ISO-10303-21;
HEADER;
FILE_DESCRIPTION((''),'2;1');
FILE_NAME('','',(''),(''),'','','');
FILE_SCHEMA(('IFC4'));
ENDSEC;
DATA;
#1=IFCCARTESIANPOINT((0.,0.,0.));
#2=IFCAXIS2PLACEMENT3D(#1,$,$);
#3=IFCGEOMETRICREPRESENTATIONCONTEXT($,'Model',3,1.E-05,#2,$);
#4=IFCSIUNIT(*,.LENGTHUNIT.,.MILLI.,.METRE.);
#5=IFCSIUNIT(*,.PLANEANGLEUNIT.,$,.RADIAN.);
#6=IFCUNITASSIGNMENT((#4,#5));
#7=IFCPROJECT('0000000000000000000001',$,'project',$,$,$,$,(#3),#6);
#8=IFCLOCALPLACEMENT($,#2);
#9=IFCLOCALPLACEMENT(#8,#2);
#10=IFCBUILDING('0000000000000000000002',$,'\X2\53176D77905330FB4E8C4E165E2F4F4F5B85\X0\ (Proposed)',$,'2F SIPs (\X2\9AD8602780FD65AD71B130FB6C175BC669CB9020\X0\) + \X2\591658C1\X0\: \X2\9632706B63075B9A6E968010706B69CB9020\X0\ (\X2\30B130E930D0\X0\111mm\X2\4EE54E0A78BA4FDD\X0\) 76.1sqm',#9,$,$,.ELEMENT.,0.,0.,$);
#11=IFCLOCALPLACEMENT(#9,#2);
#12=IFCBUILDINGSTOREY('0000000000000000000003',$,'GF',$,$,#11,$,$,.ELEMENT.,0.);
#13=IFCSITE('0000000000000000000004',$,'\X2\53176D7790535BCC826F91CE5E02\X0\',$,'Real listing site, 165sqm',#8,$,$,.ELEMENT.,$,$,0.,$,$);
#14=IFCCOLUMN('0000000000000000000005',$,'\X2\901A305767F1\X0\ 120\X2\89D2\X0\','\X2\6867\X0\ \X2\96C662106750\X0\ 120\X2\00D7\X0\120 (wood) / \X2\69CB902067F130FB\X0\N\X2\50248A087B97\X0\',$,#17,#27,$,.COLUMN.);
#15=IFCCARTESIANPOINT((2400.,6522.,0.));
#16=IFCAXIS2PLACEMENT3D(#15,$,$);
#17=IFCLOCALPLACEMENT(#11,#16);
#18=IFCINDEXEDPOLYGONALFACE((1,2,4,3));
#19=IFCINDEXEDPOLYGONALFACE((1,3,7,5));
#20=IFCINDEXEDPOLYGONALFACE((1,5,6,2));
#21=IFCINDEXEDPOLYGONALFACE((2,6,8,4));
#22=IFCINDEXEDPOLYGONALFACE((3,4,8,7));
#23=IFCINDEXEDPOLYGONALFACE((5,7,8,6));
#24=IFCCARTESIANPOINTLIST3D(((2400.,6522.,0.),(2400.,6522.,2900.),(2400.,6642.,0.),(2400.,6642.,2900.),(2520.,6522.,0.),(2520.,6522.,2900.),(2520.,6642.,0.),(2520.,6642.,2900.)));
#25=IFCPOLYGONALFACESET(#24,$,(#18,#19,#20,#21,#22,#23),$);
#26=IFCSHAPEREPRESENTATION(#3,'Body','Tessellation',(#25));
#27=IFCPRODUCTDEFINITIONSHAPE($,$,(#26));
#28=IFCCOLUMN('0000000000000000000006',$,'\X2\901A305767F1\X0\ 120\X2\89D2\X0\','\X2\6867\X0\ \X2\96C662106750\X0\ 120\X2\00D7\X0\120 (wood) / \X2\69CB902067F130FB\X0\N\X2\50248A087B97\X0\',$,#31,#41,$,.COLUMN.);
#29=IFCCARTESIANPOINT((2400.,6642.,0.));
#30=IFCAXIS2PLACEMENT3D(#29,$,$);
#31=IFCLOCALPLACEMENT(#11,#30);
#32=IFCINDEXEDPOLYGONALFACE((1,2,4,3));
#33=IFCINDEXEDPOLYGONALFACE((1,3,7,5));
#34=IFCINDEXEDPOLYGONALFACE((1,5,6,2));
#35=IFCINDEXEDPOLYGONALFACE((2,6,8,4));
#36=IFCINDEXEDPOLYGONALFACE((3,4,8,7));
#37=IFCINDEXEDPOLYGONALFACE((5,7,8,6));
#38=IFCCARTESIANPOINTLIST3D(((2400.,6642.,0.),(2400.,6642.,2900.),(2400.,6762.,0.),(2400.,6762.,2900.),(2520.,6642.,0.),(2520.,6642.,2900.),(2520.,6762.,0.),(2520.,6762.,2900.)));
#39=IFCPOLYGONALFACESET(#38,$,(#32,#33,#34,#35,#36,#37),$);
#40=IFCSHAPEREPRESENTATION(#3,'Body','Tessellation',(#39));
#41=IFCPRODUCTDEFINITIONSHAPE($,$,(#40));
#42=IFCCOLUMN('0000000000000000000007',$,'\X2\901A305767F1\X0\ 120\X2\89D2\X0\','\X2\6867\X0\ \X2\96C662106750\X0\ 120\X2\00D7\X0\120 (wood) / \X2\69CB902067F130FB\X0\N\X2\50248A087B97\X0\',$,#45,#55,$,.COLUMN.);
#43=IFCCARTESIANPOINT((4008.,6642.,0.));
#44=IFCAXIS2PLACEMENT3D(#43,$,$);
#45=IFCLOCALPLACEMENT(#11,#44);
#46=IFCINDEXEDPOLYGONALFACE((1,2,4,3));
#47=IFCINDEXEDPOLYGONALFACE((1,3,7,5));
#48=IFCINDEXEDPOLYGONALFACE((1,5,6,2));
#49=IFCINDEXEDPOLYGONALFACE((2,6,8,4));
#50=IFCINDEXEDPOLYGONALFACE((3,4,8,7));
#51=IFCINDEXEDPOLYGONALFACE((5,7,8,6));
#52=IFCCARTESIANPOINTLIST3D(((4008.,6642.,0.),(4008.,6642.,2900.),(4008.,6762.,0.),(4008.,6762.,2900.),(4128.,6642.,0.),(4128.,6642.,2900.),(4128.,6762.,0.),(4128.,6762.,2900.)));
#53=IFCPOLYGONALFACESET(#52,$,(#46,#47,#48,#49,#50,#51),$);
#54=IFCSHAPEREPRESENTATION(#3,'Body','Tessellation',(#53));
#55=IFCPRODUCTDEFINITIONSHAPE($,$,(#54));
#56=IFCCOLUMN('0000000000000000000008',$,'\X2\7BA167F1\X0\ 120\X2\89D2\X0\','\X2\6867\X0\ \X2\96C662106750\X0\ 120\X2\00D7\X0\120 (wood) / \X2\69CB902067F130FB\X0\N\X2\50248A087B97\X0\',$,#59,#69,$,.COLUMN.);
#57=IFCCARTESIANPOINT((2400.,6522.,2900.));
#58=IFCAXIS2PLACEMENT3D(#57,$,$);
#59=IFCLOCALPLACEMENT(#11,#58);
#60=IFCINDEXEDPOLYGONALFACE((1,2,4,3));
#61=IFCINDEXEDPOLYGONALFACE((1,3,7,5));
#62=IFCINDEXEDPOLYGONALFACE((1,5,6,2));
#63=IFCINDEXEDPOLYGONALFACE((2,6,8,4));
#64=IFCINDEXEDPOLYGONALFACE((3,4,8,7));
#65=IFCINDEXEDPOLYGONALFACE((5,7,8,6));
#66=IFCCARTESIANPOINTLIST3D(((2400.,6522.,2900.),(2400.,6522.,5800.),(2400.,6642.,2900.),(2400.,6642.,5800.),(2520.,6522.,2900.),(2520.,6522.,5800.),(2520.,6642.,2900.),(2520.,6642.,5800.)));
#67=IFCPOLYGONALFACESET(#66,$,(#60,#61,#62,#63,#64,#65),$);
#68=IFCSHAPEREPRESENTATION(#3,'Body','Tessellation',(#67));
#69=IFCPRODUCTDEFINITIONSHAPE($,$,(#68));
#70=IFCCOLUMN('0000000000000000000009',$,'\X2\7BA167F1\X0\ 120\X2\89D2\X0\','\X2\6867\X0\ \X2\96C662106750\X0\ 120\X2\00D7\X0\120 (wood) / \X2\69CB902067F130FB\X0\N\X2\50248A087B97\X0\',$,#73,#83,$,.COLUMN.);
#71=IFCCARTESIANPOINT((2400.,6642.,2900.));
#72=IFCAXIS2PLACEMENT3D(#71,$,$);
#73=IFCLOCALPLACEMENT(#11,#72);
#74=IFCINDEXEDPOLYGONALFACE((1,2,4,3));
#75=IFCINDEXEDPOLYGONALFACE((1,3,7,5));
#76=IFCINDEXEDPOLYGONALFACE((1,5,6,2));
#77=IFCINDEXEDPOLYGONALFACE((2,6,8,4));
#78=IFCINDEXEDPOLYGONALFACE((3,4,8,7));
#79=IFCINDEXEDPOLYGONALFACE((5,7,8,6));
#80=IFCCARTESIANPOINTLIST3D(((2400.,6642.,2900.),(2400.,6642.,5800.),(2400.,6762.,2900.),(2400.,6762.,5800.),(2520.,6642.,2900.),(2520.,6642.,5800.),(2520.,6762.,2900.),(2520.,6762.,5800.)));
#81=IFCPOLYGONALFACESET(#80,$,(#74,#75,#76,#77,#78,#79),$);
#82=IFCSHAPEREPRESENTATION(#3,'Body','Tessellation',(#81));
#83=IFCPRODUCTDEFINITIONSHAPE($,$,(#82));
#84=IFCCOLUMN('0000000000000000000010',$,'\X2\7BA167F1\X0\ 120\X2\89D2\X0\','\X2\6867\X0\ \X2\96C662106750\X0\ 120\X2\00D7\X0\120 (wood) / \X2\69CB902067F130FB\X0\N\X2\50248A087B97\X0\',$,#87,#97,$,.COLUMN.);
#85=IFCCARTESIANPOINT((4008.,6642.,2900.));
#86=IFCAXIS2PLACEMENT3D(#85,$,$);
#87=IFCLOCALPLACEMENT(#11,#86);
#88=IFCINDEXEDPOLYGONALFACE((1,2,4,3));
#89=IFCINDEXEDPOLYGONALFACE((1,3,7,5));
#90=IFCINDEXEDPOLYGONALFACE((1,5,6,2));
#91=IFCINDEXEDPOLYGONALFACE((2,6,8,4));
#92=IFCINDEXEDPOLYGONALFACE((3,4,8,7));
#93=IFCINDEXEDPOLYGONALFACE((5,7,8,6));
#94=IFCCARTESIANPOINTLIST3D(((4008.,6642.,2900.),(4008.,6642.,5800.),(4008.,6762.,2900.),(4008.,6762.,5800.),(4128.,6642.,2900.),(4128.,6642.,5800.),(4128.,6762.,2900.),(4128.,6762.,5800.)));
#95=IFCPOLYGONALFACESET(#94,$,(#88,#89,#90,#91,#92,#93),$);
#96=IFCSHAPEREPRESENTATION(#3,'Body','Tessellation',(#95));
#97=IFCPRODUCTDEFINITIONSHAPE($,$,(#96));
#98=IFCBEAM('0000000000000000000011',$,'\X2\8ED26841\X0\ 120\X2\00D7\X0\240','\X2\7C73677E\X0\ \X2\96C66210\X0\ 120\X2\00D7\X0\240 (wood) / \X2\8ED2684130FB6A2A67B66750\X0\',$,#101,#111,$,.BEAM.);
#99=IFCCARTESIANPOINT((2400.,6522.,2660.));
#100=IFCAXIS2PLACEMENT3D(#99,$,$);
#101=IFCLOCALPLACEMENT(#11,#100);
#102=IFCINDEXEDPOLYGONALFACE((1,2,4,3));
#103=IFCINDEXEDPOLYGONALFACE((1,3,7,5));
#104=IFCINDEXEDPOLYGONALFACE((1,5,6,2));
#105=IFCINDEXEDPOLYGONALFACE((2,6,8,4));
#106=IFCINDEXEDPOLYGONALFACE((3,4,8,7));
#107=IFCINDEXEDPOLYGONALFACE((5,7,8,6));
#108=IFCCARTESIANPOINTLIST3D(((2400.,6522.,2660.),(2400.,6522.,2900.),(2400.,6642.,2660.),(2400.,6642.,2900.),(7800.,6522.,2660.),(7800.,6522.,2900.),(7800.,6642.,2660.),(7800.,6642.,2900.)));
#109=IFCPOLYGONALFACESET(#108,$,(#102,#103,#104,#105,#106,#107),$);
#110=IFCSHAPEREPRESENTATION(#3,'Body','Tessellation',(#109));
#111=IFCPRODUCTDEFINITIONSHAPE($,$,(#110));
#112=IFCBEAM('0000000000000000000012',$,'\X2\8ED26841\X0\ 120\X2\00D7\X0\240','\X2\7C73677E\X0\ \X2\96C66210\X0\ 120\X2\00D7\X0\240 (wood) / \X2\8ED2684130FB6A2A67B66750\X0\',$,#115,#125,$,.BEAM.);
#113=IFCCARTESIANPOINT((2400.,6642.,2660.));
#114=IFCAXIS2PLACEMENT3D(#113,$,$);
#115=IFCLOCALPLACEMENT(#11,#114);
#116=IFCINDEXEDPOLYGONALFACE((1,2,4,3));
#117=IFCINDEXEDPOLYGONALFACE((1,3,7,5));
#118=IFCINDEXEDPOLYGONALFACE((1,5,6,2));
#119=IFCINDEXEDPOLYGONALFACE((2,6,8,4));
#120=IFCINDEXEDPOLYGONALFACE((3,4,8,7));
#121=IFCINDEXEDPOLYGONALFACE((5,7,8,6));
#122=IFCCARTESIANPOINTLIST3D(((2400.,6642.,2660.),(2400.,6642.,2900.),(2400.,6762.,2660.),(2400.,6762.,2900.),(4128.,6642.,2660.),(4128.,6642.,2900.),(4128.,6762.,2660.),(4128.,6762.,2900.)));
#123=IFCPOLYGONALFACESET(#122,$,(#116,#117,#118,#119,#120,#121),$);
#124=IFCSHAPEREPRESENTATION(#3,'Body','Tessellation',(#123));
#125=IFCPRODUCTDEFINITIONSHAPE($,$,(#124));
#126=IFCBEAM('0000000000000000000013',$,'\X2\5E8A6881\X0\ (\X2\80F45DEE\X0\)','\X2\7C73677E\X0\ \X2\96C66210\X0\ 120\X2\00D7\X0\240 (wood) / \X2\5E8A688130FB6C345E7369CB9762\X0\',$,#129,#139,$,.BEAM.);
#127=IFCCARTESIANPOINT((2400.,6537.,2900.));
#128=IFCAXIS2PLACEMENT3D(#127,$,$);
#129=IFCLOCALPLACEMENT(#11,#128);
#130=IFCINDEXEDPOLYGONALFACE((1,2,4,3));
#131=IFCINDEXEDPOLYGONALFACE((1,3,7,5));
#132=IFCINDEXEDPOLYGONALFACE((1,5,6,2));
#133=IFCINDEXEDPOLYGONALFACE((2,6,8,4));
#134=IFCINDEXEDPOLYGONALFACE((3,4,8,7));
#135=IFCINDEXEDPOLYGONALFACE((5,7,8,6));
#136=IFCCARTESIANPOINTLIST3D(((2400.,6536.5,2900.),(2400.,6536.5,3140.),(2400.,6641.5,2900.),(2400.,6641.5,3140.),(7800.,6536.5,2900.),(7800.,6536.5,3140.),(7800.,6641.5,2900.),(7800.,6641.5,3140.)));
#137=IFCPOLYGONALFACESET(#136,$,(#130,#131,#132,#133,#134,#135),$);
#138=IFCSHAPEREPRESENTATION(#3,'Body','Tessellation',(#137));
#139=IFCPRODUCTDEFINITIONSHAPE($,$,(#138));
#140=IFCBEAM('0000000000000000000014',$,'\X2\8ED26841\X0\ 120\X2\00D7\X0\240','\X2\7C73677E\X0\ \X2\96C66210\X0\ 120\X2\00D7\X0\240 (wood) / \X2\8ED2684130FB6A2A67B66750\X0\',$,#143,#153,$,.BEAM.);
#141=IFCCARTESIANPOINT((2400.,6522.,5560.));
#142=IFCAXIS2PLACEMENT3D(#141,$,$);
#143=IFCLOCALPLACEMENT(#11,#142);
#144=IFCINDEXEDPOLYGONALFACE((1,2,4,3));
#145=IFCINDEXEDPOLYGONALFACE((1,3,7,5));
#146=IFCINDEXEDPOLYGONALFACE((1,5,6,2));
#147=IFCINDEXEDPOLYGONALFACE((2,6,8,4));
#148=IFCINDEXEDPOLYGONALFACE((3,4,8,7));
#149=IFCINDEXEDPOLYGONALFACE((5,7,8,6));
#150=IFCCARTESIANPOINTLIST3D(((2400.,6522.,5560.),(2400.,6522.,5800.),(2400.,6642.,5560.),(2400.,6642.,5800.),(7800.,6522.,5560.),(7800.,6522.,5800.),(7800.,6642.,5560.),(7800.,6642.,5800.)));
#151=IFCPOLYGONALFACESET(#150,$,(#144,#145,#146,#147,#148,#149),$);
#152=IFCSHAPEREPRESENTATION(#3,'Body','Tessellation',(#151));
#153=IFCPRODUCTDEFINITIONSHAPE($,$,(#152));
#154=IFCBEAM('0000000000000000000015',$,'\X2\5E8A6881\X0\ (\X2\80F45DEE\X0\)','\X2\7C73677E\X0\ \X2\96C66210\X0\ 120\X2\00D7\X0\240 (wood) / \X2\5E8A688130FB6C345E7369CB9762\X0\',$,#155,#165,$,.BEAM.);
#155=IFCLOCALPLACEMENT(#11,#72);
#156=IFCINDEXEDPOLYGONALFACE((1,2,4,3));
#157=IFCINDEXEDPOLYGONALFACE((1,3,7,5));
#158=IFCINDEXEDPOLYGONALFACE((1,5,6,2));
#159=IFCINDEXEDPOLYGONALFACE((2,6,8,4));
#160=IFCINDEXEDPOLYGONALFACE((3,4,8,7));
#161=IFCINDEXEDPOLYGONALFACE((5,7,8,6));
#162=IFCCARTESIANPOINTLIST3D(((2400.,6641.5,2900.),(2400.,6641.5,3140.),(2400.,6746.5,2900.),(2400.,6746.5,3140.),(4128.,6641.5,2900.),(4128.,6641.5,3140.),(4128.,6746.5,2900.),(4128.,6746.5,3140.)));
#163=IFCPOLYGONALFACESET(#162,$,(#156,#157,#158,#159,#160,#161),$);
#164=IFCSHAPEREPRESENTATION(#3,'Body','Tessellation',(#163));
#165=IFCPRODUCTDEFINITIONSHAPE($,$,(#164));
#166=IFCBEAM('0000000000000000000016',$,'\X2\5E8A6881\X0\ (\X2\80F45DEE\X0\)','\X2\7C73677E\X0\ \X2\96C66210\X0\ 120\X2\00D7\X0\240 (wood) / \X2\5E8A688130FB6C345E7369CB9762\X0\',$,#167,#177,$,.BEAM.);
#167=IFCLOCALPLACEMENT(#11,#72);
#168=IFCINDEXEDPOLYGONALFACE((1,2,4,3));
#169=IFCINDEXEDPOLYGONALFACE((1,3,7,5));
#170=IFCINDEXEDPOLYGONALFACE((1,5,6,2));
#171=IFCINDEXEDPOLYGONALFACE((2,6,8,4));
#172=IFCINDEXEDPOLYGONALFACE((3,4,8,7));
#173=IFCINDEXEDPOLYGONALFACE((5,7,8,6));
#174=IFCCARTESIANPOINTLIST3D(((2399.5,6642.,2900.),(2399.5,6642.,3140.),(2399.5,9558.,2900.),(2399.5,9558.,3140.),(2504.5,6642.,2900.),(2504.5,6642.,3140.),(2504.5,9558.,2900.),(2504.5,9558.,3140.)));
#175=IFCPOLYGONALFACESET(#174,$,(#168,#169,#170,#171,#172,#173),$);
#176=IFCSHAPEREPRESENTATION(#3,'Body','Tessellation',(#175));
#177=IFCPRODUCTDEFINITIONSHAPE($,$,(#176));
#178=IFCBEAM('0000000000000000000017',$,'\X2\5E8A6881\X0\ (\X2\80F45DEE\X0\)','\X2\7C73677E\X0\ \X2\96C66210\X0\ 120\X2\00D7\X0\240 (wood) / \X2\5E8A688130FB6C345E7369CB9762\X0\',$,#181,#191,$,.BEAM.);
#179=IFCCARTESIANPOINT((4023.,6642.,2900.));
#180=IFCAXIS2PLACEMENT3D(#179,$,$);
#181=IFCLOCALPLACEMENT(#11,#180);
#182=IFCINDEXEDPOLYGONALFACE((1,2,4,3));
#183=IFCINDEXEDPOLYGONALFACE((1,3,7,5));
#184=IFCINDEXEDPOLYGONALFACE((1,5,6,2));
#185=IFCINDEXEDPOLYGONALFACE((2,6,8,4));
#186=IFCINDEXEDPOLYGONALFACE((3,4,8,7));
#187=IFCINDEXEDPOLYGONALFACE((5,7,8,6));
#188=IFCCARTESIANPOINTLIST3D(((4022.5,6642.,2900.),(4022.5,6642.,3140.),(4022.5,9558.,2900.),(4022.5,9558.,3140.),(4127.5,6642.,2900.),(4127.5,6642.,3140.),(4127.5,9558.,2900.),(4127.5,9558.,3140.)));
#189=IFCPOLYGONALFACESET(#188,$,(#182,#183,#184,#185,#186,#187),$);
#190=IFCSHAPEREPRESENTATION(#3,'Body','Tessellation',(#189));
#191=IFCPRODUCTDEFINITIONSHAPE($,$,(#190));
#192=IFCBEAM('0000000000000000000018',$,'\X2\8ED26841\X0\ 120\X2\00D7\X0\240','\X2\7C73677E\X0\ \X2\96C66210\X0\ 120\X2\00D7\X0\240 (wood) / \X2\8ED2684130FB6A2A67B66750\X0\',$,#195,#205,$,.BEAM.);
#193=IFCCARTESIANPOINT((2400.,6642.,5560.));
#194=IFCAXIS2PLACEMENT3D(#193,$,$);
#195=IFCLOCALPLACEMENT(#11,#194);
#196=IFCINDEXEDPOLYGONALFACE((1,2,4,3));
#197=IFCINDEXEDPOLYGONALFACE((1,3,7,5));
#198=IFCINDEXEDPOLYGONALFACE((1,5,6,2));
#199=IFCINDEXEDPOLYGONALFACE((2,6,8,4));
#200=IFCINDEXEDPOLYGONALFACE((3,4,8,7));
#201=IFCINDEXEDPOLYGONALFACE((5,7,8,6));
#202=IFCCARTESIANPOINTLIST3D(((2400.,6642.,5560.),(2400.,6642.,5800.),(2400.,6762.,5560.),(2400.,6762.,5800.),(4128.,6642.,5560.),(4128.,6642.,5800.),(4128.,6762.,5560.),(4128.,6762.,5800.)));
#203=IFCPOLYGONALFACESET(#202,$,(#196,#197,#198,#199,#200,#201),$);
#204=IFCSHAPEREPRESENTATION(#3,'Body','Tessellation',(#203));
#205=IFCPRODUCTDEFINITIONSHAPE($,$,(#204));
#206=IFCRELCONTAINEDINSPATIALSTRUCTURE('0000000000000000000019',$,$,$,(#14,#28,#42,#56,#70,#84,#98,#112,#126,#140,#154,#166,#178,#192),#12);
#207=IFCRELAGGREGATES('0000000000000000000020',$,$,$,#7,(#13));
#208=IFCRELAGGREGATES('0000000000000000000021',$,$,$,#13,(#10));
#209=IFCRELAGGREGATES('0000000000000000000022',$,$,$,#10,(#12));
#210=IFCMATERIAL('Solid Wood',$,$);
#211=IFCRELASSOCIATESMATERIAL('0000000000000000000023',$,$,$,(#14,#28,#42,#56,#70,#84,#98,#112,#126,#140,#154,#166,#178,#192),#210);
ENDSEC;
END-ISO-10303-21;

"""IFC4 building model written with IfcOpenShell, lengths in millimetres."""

from ifc_helpers import new_model, si_unit, frame, frame_2d, origin, place, context, project, spatial, rectangle, extrude, material, element, save


model = new_model("IFC4")

# Units and contexts
model_context = context("Model", 3, precision=1e-05, world=origin())
ifc_project = project(units=[si_unit("LENGTHUNIT", "METRE", prefix="MILLI"), si_unit("PLANEANGLEUNIT", "RADIAN")], contexts=[model_context])

# Site, building, storey
site_placement = place(None, origin())
site = spatial("IfcSite", under=ifc_project, at=site_placement, Name="北海道富良野市", ObjectType="Real listing site, 165sqm", CompositionType="ELEMENT", RefElevation=0.0)
building_placement = place(site_placement, origin())
building = spatial("IfcBuilding", under=site, at=building_placement, Name="北海道・二世帯住宅 (Proposed)", ObjectType="2F SIPs (高性能断熱・気密構造) + 外壁: 防火指定準耐火構造 (ケラバ111mm以上確保) 76.1sqm", CompositionType="ELEMENT", ElevationOfRefHeight=0.0, ElevationOfTerrain=0.0)
storey_placement = place(building_placement, origin())
storey = spatial("IfcBuildingStorey", under=building, at=storey_placement, Name="GF", CompositionType="ELEMENT", Elevation=0.0)

# Columns
ifc_material_1 = material(Name="Solid Wood")
column_1_placement = place(storey_placement, frame((2400.0, 6522.0, 0.0)))
element("IfcColumn", 1, at=column_1_placement, inside=storey, material=ifc_material_1, Name="通し柱 120角", Description="桧 集成材 120×120 (wood) / 構造柱・N値計算", PredefinedType="COLUMN", context=model_context, shape_type="SweptSolid", body=[
    extrude(rectangle(XDim=120.0, YDim=120.0, at=frame_2d((60.0, 60.0))), frame((2400.0, 6522.0, 0.0)), (0.0, 0.0, 1.0), 2900.0),
])
column_2_placement = place(storey_placement, frame((2400.0, 6642.0, 0.0)))
element("IfcColumn", 2, at=column_2_placement, inside=storey, material=ifc_material_1, Name="通し柱 120角", Description="桧 集成材 120×120 (wood) / 構造柱・N値計算", PredefinedType="COLUMN", context=model_context, shape_type="SweptSolid", body=[
    extrude(rectangle(XDim=120.0, YDim=120.0, at=frame_2d((60.0, 60.0))), frame((2400.0, 6642.0, 0.0)), (0.0, 0.0, 1.0), 2900.0),
])
column_3_placement = place(storey_placement, frame((4008.0, 6642.0, 0.0)))
element("IfcColumn", 3, at=column_3_placement, inside=storey, material=ifc_material_1, Name="通し柱 120角", Description="桧 集成材 120×120 (wood) / 構造柱・N値計算", PredefinedType="COLUMN", context=model_context, shape_type="SweptSolid", body=[
    extrude(rectangle(XDim=120.0, YDim=120.0, at=frame_2d((60.0, 60.0))), frame((4008.0, 6642.0, 0.0)), (0.0, 0.0, 1.0), 2900.0),
])
column_4_placement = place(storey_placement, frame((2400.0, 6522.0, 2900.0)))
element("IfcColumn", 4, at=column_4_placement, inside=storey, material=ifc_material_1, Name="管柱 120角", Description="桧 集成材 120×120 (wood) / 構造柱・N値計算", PredefinedType="COLUMN", context=model_context, shape_type="SweptSolid", body=[
    extrude(rectangle(XDim=120.0, YDim=120.0, at=frame_2d((60.0, 60.0))), frame((2400.0, 6522.0, 2900.0)), (0.0, 0.0, 1.0), 2900.0),
])
column_5_placement = place(storey_placement, frame((2400.0, 6642.0, 2900.0)))
element("IfcColumn", 5, at=column_5_placement, inside=storey, material=ifc_material_1, Name="管柱 120角", Description="桧 集成材 120×120 (wood) / 構造柱・N値計算", PredefinedType="COLUMN", context=model_context, shape_type="SweptSolid", body=[
    extrude(rectangle(XDim=120.0, YDim=120.0, at=frame_2d((60.0, 60.0))), frame((2400.0, 6642.0, 2900.0)), (0.0, 0.0, 1.0), 2900.0),
])
column_6_placement = place(storey_placement, frame((4008.0, 6642.0, 2900.0)))
element("IfcColumn", 6, at=column_6_placement, inside=storey, material=ifc_material_1, Name="管柱 120角", Description="桧 集成材 120×120 (wood) / 構造柱・N値計算", PredefinedType="COLUMN", context=model_context, shape_type="SweptSolid", body=[
    extrude(rectangle(XDim=120.0, YDim=120.0, at=frame_2d((60.0, 60.0))), frame((4008.0, 6642.0, 2900.0)), (0.0, 0.0, 1.0), 2900.0),
])

# Beams
beam_1_placement = place(storey_placement, frame((2400.0, 6522.0, 2660.0)))
element("IfcBeam", 7, at=beam_1_placement, inside=storey, material=ifc_material_1, Name="軒桁 120×240", Description="米松 集成 120×240 (wood) / 軒桁・横架材", PredefinedType="BEAM", context=model_context, shape_type="SweptSolid", body=[
    extrude(rectangle(XDim=5400.0, YDim=120.0, at=frame_2d((2700.0, 60.0))), frame((2400.0, 6522.0, 2660.0)), (0.0, 0.0, 1.0), 240.0),
])
beam_2_placement = place(storey_placement, frame((2400.0, 6642.0, 2660.0)))
element("IfcBeam", 8, at=beam_2_placement, inside=storey, material=ifc_material_1, Name="軒桁 120×240", Description="米松 集成 120×240 (wood) / 軒桁・横架材", PredefinedType="BEAM", context=model_context, shape_type="SweptSolid", body=[
    extrude(rectangle(XDim=1728.0, YDim=120.0, at=frame_2d((864.0, 60.0))), frame((2400.0, 6642.0, 2660.0)), (0.0, 0.0, 1.0), 240.0),
])
beam_3_placement = place(storey_placement, frame((2400.0, 6537.0, 2900.0)))
element("IfcBeam", 9, at=beam_3_placement, inside=storey, material=ifc_material_1, Name="床梁 (胴差)", Description="米松 集成 120×240 (wood) / 床梁・水平構面", PredefinedType="BEAM", context=model_context, shape_type="SweptSolid", body=[
    extrude(rectangle(XDim=5400.0, YDim=105.0, at=frame_2d((2700.0, 52.0))), frame((2400.0, 6537.0, 2900.0)), (0.0, 0.0, 1.0), 240.0),
])
beam_4_placement = place(storey_placement, frame((2400.0, 6522.0, 5560.0)))
element("IfcBeam", 10, at=beam_4_placement, inside=storey, material=ifc_material_1, Name="軒桁 120×240", Description="米松 集成 120×240 (wood) / 軒桁・横架材", PredefinedType="BEAM", context=model_context, shape_type="SweptSolid", body=[
    extrude(rectangle(XDim=5400.0, YDim=120.0, at=frame_2d((2700.0, 60.0))), frame((2400.0, 6522.0, 5560.0)), (0.0, 0.0, 1.0), 240.0),
])
beam_5_placement = place(storey_placement, frame((2400.0, 6642.0, 2900.0)))
element("IfcBeam", 11, at=beam_5_placement, inside=storey, material=ifc_material_1, Name="床梁 (胴差)", Description="米松 集成 120×240 (wood) / 床梁・水平構面", PredefinedType="BEAM", context=model_context, shape_type="SweptSolid", body=[
    extrude(rectangle(XDim=1728.0, YDim=105.0, at=frame_2d((864.0, 52.0))), frame((2400.0, 6642.0, 2900.0)), (0.0, 0.0, 1.0), 240.0),
])
beam_6_placement = place(storey_placement, frame((2400.0, 6642.0, 2900.0)))
element("IfcBeam", 12, at=beam_6_placement, inside=storey, material=ifc_material_1, Name="床梁 (胴差)", Description="米松 集成 120×240 (wood) / 床梁・水平構面", PredefinedType="BEAM", context=model_context, shape_type="SweptSolid", body=[
    extrude(rectangle(XDim=105.0, YDim=2916.0, at=frame_2d((52.0, 1458.0))), frame((2400.0, 6642.0, 2900.0)), (0.0, 0.0, 1.0), 240.0),
])
beam_7_placement = place(storey_placement, frame((4023.0, 6642.0, 2900.0)))
element("IfcBeam", 13, at=beam_7_placement, inside=storey, material=ifc_material_1, Name="床梁 (胴差)", Description="米松 集成 120×240 (wood) / 床梁・水平構面", PredefinedType="BEAM", context=model_context, shape_type="SweptSolid", body=[
    extrude(rectangle(XDim=105.0, YDim=2916.0, at=frame_2d((52.0, 1458.0))), frame((4023.0, 6642.0, 2900.0)), (0.0, 0.0, 1.0), 240.0),
])
beam_8_placement = place(storey_placement, frame((2400.0, 6642.0, 5560.0)))
element("IfcBeam", 14, at=beam_8_placement, inside=storey, material=ifc_material_1, Name="軒桁 120×240", Description="米松 集成 120×240 (wood) / 軒桁・横架材", PredefinedType="BEAM", context=model_context, shape_type="SweptSolid", body=[
    extrude(rectangle(XDim=1728.0, YDim=120.0, at=frame_2d((864.0, 60.0))), frame((2400.0, 6642.0, 5560.0)), (0.0, 0.0, 1.0), 240.0),
])

save(model, "model.ifc")
